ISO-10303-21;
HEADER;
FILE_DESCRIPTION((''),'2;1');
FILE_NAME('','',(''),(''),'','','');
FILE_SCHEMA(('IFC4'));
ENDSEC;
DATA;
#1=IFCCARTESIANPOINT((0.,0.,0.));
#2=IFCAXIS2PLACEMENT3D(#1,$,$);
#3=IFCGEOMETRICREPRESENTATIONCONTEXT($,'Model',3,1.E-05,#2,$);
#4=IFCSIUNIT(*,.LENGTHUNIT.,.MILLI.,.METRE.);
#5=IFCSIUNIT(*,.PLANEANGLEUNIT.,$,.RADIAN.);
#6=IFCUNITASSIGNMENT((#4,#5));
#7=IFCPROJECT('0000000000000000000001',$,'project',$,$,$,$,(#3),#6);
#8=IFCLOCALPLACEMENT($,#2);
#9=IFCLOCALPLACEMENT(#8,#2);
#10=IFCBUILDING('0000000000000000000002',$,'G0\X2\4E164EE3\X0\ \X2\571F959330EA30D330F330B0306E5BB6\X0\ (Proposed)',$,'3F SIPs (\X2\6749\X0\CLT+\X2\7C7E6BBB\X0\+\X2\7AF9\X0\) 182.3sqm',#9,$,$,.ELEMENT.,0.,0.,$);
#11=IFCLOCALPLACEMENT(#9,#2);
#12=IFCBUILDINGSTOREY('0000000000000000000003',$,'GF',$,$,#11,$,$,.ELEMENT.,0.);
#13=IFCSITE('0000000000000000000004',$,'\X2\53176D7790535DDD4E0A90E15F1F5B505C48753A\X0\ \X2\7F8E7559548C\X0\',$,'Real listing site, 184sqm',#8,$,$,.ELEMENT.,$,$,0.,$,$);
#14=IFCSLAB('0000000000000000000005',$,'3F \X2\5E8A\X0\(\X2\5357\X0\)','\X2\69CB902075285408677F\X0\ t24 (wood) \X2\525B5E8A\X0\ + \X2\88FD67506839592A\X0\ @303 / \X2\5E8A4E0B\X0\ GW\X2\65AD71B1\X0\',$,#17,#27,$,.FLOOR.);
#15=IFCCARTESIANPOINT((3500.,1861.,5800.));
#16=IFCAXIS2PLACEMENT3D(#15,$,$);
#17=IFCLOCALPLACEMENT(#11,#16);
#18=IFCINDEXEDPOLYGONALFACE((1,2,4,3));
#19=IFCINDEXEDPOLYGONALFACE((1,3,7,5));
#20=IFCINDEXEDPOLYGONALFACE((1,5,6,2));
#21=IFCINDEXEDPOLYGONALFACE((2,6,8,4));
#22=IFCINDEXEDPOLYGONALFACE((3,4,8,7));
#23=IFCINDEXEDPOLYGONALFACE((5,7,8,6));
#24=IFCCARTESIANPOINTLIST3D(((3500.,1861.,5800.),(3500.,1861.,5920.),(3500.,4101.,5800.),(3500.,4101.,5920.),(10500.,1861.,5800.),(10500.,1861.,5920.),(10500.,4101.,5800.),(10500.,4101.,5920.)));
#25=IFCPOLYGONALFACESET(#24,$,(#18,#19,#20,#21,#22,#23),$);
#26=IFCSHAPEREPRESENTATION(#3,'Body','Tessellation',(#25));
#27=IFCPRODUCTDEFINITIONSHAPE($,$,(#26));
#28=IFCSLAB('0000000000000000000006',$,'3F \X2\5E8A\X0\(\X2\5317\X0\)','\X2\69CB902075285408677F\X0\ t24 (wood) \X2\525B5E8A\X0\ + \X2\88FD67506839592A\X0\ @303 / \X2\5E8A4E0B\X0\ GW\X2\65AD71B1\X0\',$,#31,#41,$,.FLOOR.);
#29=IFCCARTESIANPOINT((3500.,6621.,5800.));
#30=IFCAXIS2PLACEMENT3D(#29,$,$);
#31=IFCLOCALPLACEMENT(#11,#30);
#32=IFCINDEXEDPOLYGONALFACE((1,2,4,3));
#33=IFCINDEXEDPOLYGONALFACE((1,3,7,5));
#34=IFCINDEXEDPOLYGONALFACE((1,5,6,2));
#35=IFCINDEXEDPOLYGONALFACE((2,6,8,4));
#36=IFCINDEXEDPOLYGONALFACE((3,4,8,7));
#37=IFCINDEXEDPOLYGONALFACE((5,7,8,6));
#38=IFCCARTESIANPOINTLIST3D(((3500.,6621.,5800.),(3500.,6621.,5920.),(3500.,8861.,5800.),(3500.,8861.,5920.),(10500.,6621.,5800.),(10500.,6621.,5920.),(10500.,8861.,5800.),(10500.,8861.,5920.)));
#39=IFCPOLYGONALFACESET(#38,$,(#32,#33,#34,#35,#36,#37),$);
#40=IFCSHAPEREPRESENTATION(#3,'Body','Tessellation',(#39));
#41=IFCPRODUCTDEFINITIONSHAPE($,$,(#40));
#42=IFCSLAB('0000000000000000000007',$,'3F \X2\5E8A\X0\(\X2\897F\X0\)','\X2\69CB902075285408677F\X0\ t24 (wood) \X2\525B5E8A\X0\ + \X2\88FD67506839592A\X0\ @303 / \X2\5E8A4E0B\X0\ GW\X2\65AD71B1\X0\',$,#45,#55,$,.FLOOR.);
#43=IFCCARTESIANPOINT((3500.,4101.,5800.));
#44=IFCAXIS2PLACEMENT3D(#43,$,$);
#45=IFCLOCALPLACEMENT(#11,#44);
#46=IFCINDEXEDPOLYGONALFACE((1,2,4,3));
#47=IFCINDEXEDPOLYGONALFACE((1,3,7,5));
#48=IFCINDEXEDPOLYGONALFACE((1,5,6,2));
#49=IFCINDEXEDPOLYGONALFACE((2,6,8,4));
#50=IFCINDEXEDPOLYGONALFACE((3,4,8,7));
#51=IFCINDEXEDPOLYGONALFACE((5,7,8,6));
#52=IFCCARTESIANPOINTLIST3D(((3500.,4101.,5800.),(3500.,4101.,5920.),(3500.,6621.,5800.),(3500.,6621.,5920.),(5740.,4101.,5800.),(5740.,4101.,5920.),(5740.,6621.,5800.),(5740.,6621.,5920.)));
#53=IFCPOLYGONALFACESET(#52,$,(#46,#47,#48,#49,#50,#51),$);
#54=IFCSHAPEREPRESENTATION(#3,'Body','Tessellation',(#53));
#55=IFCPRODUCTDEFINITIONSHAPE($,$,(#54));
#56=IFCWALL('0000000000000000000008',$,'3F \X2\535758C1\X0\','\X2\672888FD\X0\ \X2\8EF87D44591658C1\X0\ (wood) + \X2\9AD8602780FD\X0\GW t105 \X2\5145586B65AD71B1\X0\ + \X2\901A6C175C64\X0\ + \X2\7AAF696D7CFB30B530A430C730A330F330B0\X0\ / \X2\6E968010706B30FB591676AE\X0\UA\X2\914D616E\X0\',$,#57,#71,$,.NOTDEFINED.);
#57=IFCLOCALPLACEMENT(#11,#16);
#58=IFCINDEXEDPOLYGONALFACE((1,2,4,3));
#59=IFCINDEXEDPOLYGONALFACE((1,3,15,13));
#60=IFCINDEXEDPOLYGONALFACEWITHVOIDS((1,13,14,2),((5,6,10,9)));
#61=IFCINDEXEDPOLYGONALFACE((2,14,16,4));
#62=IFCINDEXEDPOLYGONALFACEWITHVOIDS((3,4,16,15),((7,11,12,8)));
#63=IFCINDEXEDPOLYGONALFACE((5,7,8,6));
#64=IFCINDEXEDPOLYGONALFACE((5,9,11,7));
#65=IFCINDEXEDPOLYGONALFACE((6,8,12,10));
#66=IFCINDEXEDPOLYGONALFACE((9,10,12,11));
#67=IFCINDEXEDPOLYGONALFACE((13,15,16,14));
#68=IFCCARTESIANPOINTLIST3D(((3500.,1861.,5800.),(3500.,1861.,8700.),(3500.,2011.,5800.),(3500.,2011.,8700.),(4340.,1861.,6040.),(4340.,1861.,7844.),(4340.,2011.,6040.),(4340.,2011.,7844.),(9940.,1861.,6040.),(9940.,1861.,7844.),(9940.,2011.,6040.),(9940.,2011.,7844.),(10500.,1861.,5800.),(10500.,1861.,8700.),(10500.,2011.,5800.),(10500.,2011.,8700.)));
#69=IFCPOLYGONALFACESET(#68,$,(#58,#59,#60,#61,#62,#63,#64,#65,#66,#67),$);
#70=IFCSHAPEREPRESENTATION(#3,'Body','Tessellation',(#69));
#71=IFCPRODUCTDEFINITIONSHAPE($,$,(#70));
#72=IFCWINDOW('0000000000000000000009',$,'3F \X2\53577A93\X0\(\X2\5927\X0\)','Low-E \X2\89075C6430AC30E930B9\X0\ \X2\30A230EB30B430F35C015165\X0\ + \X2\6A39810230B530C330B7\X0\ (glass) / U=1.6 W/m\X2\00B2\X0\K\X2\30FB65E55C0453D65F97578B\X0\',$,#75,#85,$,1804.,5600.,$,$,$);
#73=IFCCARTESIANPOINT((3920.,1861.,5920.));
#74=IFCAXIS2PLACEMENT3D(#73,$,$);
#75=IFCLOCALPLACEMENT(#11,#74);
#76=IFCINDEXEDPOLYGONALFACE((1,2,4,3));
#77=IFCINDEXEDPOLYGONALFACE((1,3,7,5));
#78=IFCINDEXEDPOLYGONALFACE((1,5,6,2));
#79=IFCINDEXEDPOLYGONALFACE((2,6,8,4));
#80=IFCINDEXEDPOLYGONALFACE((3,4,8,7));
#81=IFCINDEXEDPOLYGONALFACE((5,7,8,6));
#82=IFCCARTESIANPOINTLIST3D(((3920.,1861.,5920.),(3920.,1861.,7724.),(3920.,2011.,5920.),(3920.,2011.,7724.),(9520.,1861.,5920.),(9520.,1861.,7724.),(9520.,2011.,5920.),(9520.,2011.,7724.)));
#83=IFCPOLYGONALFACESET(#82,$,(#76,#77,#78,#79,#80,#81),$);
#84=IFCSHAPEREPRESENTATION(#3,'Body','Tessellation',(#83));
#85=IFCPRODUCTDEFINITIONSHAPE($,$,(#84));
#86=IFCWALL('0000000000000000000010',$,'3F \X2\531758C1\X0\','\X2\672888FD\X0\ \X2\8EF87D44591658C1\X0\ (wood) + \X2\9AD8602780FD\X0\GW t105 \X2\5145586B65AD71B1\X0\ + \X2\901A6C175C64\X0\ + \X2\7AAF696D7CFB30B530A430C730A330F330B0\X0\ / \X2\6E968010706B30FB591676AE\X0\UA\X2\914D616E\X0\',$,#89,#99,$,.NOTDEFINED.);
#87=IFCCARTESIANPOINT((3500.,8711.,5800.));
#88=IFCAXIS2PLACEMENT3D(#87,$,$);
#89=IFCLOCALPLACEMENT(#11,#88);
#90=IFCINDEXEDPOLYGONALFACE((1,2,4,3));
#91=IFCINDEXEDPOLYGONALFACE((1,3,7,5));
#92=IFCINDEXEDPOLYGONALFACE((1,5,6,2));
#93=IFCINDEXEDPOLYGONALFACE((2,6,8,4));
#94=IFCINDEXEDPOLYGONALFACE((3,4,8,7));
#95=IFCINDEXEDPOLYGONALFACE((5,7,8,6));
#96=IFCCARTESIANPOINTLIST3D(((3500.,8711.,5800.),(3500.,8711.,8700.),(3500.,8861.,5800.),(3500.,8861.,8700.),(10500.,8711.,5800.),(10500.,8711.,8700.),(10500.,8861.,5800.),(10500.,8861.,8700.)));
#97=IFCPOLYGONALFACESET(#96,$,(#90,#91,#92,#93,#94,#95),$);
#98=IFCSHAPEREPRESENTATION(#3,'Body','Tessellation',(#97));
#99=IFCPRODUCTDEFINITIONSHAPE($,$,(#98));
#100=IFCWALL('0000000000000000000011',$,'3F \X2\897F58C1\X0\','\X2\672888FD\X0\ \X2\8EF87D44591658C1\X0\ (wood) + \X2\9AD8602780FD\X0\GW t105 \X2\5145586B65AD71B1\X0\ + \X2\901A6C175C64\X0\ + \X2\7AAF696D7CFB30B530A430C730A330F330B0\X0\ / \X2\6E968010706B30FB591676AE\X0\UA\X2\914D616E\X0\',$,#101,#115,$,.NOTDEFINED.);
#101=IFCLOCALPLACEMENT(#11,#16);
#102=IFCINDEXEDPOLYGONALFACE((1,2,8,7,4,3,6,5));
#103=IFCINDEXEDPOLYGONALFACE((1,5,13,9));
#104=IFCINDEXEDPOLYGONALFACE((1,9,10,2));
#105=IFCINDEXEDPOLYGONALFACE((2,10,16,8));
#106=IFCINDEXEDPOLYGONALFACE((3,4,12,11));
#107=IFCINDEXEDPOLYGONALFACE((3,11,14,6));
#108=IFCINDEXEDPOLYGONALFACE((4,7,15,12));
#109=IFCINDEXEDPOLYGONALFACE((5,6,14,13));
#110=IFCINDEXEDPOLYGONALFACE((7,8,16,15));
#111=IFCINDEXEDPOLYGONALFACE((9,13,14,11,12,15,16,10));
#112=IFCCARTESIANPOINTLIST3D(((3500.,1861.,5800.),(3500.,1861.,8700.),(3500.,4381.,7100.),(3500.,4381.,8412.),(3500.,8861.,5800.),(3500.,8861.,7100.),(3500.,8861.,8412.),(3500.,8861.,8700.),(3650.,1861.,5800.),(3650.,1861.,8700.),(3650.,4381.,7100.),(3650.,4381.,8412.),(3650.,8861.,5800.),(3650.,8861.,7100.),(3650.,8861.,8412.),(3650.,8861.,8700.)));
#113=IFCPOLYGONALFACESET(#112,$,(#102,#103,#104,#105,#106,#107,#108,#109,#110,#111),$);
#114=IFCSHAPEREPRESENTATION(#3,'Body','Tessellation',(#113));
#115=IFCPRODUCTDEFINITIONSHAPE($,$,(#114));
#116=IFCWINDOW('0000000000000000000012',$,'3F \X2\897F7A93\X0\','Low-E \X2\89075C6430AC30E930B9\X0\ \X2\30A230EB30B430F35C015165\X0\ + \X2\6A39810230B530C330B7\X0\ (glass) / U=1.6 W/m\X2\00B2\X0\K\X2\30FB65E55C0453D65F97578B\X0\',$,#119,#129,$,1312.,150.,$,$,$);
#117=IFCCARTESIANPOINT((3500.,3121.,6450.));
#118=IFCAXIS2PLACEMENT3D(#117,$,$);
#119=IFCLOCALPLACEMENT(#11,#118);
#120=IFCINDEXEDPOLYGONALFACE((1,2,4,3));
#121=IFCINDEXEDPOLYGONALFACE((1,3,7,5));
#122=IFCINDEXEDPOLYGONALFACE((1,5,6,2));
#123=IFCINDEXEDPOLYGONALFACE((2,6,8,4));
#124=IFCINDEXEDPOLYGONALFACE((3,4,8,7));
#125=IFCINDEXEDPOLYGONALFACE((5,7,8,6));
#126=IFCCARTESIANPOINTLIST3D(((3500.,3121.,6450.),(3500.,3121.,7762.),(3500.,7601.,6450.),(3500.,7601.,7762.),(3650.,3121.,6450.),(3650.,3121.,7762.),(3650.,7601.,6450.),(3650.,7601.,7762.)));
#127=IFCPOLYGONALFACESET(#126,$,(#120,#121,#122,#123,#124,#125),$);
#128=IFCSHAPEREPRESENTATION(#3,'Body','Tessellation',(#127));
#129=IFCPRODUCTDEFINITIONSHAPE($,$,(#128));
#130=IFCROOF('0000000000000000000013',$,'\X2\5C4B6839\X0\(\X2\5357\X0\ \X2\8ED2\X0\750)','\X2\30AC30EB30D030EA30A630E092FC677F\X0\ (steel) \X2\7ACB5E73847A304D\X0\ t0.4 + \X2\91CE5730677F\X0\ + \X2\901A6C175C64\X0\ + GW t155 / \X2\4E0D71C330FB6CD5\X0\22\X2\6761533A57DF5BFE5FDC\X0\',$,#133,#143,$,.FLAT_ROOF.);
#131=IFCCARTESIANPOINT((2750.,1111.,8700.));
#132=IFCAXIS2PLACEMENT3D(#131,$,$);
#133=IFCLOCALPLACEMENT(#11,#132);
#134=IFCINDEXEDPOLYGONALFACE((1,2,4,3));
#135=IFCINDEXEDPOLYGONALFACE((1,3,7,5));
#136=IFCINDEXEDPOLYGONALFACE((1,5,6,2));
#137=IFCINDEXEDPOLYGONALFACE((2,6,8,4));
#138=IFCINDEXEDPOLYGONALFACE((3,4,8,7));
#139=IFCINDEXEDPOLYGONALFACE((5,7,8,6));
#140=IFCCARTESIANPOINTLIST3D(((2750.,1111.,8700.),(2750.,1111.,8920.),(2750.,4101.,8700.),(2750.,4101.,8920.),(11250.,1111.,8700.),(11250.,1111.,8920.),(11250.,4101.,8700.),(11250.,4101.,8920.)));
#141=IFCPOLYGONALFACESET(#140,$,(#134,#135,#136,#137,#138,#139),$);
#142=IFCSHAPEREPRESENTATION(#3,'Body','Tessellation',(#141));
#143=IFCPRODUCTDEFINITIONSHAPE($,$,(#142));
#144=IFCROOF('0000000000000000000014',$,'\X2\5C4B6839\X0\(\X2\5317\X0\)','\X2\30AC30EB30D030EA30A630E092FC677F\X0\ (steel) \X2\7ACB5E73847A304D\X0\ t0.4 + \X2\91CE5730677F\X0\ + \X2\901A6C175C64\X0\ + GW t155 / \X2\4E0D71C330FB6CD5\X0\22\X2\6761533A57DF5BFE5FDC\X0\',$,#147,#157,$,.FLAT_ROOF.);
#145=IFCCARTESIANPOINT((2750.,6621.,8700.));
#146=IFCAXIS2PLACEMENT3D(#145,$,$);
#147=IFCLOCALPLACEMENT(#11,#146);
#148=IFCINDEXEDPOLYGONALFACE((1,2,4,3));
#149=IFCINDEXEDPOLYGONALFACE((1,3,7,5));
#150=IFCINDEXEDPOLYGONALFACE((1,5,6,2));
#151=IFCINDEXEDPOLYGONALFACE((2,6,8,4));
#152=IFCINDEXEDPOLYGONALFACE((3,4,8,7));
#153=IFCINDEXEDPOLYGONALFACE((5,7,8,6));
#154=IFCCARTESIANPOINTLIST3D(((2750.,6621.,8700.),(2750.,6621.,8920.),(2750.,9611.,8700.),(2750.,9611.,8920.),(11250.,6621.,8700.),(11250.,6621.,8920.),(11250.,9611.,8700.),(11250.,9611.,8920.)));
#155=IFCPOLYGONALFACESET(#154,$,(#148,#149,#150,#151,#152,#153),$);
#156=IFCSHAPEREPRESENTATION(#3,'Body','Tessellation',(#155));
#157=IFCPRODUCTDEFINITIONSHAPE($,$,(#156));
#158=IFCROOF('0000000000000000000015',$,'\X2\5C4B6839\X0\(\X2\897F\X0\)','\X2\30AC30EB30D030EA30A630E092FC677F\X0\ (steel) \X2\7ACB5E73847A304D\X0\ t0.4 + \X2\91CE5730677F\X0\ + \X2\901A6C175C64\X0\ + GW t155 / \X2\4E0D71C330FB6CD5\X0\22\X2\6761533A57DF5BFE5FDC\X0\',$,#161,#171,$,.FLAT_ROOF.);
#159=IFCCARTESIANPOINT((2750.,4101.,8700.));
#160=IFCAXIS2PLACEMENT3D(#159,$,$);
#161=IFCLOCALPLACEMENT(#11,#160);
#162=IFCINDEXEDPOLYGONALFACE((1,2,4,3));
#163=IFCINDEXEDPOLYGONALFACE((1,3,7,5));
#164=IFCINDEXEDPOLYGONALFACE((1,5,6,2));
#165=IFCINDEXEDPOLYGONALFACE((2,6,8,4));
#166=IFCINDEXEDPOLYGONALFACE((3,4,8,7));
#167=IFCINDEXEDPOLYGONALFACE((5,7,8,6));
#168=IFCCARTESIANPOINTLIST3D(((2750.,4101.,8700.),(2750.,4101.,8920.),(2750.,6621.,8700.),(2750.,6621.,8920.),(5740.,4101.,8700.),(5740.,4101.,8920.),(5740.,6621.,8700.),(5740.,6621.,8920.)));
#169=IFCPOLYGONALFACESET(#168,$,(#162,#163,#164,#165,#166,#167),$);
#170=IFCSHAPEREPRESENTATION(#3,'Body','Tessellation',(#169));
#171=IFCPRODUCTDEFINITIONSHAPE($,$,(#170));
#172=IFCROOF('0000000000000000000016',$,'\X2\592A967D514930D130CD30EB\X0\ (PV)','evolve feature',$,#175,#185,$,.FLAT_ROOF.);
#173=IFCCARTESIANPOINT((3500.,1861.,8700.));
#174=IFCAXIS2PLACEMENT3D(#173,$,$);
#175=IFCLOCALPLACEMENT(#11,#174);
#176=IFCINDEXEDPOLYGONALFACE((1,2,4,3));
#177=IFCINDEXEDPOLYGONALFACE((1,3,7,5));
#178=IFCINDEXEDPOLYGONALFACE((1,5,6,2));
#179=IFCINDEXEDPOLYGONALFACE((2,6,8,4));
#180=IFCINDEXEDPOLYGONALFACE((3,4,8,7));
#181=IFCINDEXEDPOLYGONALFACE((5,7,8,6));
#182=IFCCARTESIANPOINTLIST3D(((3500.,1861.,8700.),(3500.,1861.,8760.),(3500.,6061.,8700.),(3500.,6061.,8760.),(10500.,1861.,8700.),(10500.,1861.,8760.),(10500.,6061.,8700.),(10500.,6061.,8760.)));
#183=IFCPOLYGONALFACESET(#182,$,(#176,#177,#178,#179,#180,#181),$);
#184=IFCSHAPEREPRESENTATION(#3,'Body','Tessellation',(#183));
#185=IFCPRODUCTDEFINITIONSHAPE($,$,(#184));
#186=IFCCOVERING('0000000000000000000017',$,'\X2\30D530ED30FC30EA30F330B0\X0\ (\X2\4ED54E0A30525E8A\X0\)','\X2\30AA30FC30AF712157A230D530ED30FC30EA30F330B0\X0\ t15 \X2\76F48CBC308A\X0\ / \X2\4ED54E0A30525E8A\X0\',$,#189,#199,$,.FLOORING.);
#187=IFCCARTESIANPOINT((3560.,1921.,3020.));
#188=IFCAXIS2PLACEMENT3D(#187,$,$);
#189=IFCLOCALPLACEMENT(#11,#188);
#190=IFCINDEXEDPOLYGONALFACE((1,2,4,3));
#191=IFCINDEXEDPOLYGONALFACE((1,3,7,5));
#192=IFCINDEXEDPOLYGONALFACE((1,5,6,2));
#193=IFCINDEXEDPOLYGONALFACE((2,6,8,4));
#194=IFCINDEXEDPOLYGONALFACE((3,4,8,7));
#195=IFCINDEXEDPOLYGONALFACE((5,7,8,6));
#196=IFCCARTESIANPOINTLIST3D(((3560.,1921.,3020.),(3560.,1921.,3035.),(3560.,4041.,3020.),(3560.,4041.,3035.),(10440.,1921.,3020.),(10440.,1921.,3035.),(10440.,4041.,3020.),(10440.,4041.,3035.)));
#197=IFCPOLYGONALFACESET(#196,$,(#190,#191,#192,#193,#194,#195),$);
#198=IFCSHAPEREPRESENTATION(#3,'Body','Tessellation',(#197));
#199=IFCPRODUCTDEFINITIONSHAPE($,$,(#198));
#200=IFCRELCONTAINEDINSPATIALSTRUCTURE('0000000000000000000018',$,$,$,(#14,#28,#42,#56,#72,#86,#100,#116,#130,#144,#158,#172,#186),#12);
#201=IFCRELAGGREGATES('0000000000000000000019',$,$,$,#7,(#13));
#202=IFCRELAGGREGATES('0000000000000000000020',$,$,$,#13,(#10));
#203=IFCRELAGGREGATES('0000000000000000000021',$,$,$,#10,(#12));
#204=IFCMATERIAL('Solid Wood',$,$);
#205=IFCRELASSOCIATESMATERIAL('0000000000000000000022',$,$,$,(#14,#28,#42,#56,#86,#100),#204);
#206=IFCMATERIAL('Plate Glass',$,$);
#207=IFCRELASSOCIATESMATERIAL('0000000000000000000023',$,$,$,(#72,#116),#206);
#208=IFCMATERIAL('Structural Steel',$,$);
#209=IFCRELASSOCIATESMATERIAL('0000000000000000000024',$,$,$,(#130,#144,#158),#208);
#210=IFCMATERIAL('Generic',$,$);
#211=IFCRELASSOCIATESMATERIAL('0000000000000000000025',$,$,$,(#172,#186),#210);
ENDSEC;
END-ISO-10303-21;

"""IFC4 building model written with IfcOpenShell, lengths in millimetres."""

from ifc_helpers import new_model, si_unit, frame, frame_2d, origin, place, context, project, spatial, rectangle, extrude, material, element, fill, save


model = new_model("IFC4")

# Units and contexts
model_context = context("Model", 3, precision=1e-05, world=origin())
ifc_project = project(units=[si_unit("LENGTHUNIT", "METRE", prefix="MILLI"), si_unit("PLANEANGLEUNIT", "RADIAN")], contexts=[model_context])

# Site, building, storey
site_placement = place(None, origin())
site = spatial("IfcSite", under=ifc_project, at=site_placement, Name="北海道川上郡弟子屈町 美留和", ObjectType="Real listing site, 184sqm", CompositionType="ELEMENT", RefElevation=0.0)
building_placement = place(site_placement, origin())
building = spatial("IfcBuilding", under=site, at=building_placement, Name="G0世代 土間リビングの家 (Proposed)", ObjectType="3F SIPs (杉CLT+籾殻+竹) 182.3sqm", CompositionType="ELEMENT", ElevationOfRefHeight=0.0, ElevationOfTerrain=0.0)
storey_placement = place(building_placement, origin())
storey = spatial("IfcBuildingStorey", under=building, at=storey_placement, Name="GF", CompositionType="ELEMENT", Elevation=0.0)

# Slabs
ifc_material_1 = material(Name="Solid Wood")
slab_1_placement = place(storey_placement, frame((3500.0, 1861.0, 5800.0)))
element("IfcSlab", 1, at=slab_1_placement, inside=storey, material=ifc_material_1, Name="3F 床(南)", Description="構造用合板 t24 (wood) 剛床 + 製材根太 @303 / 床下 GW断熱", PredefinedType="FLOOR", context=model_context, shape_type="SweptSolid", body=[
    extrude(rectangle(XDim=7000.0, YDim=2240.0, at=frame_2d((3500.0, 1120.0))), frame((3500.0, 1861.0, 5800.0)), (0.0, 0.0, 1.0), 120.0),
])
slab_2_placement = place(storey_placement, frame((3500.0, 6621.0, 5800.0)))
element("IfcSlab", 2, at=slab_2_placement, inside=storey, material=ifc_material_1, Name="3F 床(北)", Description="構造用合板 t24 (wood) 剛床 + 製材根太 @303 / 床下 GW断熱", PredefinedType="FLOOR", context=model_context, shape_type="SweptSolid", body=[
    extrude(rectangle(XDim=7000.0, YDim=2240.0, at=frame_2d((3500.0, 1120.0))), frame((3500.0, 6621.0, 5800.0)), (0.0, 0.0, 1.0), 120.0),
])
slab_3_placement = place(storey_placement, frame((3500.0, 4101.0, 5800.0)))
element("IfcSlab", 3, at=slab_3_placement, inside=storey, material=ifc_material_1, Name="3F 床(西)", Description="構造用合板 t24 (wood) 剛床 + 製材根太 @303 / 床下 GW断熱", PredefinedType="FLOOR", context=model_context, shape_type="SweptSolid", body=[
    extrude(rectangle(XDim=2240.0, YDim=2520.0, at=frame_2d((1120.0, 1260.0))), frame((3500.0, 4101.0, 5800.0)), (0.0, 0.0, 1.0), 120.0),
])

# Wall, opening, window
wall_1_placement = place(storey_placement, frame((3500.0, 1861.0, 5800.0)))
wall_1 = element("IfcWall", 4, at=wall_1_placement, inside=storey, material=ifc_material_1, Name="3F 南壁", Description="木製 軸組外壁 (wood) + 高性能GW t105 充填断熱 + 通気層 + 窯業系サイディング / 準耐火・外皮UA配慮", PredefinedType="NOTDEFINED", context=model_context, shape_type="SweptSolid", body=[
    extrude(rectangle(XDim=7000.0, YDim=150.0, at=frame_2d((3500.0, 75.0))), frame((3500.0, 1861.0, 5800.0)), (0.0, 0.0, 1.0), 2900.0),
])
opening_1_placement = place(storey_placement, frame((3920.0, 1861.0, 5920.0)))
opening_1 = element("IfcOpeningElement", 5, at=opening_1_placement, cuts=wall_1, PredefinedType="NOTDEFINED", context=model_context, shape_type="SweptSolid", body=[
    extrude(rectangle(XDim=5600.0, YDim=150.0, at=frame_2d((2800.0, 75.0))), frame((3920.0, 1861.0, 5920.0)), (0.0, 0.0, 1.0), 1804.0),
])
ifc_material_2 = material(Name="Plate Glass")
window_1_placement = place(storey_placement, frame((3920.0, 1861.0, 5920.0)))
window_1 = element("IfcWindow", 6, at=window_1_placement, inside=storey, material=ifc_material_2, Name="3F 南窓(大)", Description="Low-E 複層ガラス アルゴン封入 + 樹脂サッシ (glass) / U=1.6 W/m²K・日射取得型", OverallHeight=1804.0, OverallWidth=5600.0, context=model_context, shape_type="SweptSolid", body=[
    extrude(rectangle(XDim=5600.0, YDim=150.0, at=frame_2d((2800.0, 75.0))), frame((3920.0, 1861.0, 5920.0)), (0.0, 0.0, 1.0), 1804.0),
])
fill(opening_1, window_1)

# Wall
wall_2_placement = place(storey_placement, frame((3500.0, 8711.0, 5800.0)))
element("IfcWall", 7, at=wall_2_placement, inside=storey, material=ifc_material_1, Name="3F 北壁", Description="木製 軸組外壁 (wood) + 高性能GW t105 充填断熱 + 通気層 + 窯業系サイディング / 準耐火・外皮UA配慮", PredefinedType="NOTDEFINED", context=model_context, shape_type="SweptSolid", body=[
    extrude(rectangle(XDim=7000.0, YDim=150.0, at=frame_2d((3500.0, 75.0))), frame((3500.0, 8711.0, 5800.0)), (0.0, 0.0, 1.0), 2900.0),
])

# Wall, opening, window
wall_3_placement = place(storey_placement, frame((3500.0, 1861.0, 5800.0)))
wall_3 = element("IfcWall", 8, at=wall_3_placement, inside=storey, material=ifc_material_1, Name="3F 西壁", Description="木製 軸組外壁 (wood) + 高性能GW t105 充填断熱 + 通気層 + 窯業系サイディング / 準耐火・外皮UA配慮", PredefinedType="NOTDEFINED", context=model_context, shape_type="SweptSolid", body=[
    extrude(rectangle(XDim=150.0, YDim=7000.0, at=frame_2d((75.0, 3500.0))), frame((3500.0, 1861.0, 5800.0)), (0.0, 0.0, 1.0), 2900.0),
])
opening_2_placement = place(storey_placement, frame((3500.0, 3121.0, 6450.0)))
opening_2 = element("IfcOpeningElement", 9, at=opening_2_placement, cuts=wall_3, PredefinedType="NOTDEFINED", context=model_context, shape_type="SweptSolid", body=[
    extrude(rectangle(XDim=150.0, YDim=4480.0, at=frame_2d((75.0, 2240.0))), frame((3500.0, 3121.0, 6450.0)), (0.0, 0.0, 1.0), 1312.0),
])
window_2_placement = place(storey_placement, frame((3500.0, 3121.0, 6450.0)))
window_2 = element("IfcWindow", 10, at=window_2_placement, inside=storey, material=ifc_material_2, Name="3F 西窓", Description="Low-E 複層ガラス アルゴン封入 + 樹脂サッシ (glass) / U=1.6 W/m²K・日射取得型", OverallHeight=1312.0, OverallWidth=150.0, context=model_context, shape_type="SweptSolid", body=[
    extrude(rectangle(XDim=150.0, YDim=4480.0, at=frame_2d((75.0, 2240.0))), frame((3500.0, 3121.0, 6450.0)), (0.0, 0.0, 1.0), 1312.0),
])
fill(opening_2, window_2)

# Roofs
ifc_material_3 = material(Name="Structural Steel")
roof_1_placement = place(storey_placement, frame((2750.0, 1111.0, 8700.0)))
element("IfcRoof", 11, at=roof_1_placement, inside=storey, material=ifc_material_3, Name="屋根(南 軒750)", Description="ガルバリウム鋼板 (steel) 立平葺き t0.4 + 野地板 + 通気層 + GW t155 / 不燃・法22条区域対応", PredefinedType="FLAT_ROOF", context=model_context, shape_type="SweptSolid", body=[
    extrude(rectangle(XDim=8500.0, YDim=2990.0, at=frame_2d((4250.0, 1495.0))), frame((2750.0, 1111.0, 8700.0)), (0.0, 0.0, 1.0), 220.0),
])
roof_2_placement = place(storey_placement, frame((2750.0, 6621.0, 8700.0)))
element("IfcRoof", 12, at=roof_2_placement, inside=storey, material=ifc_material_3, Name="屋根(北)", Description="ガルバリウム鋼板 (steel) 立平葺き t0.4 + 野地板 + 通気層 + GW t155 / 不燃・法22条区域対応", PredefinedType="FLAT_ROOF", context=model_context, shape_type="SweptSolid", body=[
    extrude(rectangle(XDim=8500.0, YDim=2990.0, at=frame_2d((4250.0, 1495.0))), frame((2750.0, 6621.0, 8700.0)), (0.0, 0.0, 1.0), 220.0),
])
roof_3_placement = place(storey_placement, frame((2750.0, 4101.0, 8700.0)))
element("IfcRoof", 13, at=roof_3_placement, inside=storey, material=ifc_material_3, Name="屋根(西)", Description="ガルバリウム鋼板 (steel) 立平葺き t0.4 + 野地板 + 通気層 + GW t155 / 不燃・法22条区域対応", PredefinedType="FLAT_ROOF", context=model_context, shape_type="SweptSolid", body=[
    extrude(rectangle(XDim=2990.0, YDim=2520.0, at=frame_2d((1495.0, 1260.0))), frame((2750.0, 4101.0, 8700.0)), (0.0, 0.0, 1.0), 220.0),
])
ifc_material_4 = material(Name="Generic")
roof_4_placement = place(storey_placement, frame((3500.0, 1861.0, 8700.0)))
element("IfcRoof", 14, at=roof_4_placement, inside=storey, material=ifc_material_4, Name="太陽光パネル (PV)", Description="evolve feature", PredefinedType="FLAT_ROOF", context=model_context, shape_type="SweptSolid", body=[
    extrude(rectangle(XDim=7000.0, YDim=4200.0, at=frame_2d((3500.0, 2100.0))), frame((3500.0, 1861.0, 8700.0)), (0.0, 0.0, 1.0), 60.0),
])

# Covering
covering_1_placement = place(storey_placement, frame((3560.0, 1921.0, 3020.0)))
element("IfcCovering", 15, at=covering_1_placement, inside=storey, material=ifc_material_4, Name="フローリング (仕上げ床)", Description="オーク無垢フローリング t15 直貼り / 仕上げ床", PredefinedType="FLOORING", context=model_context, shape_type="SweptSolid", body=[
    extrude(rectangle(XDim=6880.0, YDim=2120.0, at=frame_2d((3440.0, 1060.0))), frame((3560.0, 1921.0, 3020.0)), (0.0, 0.0, 1.0), 15.0),
])

save(model, "model.ifc")
